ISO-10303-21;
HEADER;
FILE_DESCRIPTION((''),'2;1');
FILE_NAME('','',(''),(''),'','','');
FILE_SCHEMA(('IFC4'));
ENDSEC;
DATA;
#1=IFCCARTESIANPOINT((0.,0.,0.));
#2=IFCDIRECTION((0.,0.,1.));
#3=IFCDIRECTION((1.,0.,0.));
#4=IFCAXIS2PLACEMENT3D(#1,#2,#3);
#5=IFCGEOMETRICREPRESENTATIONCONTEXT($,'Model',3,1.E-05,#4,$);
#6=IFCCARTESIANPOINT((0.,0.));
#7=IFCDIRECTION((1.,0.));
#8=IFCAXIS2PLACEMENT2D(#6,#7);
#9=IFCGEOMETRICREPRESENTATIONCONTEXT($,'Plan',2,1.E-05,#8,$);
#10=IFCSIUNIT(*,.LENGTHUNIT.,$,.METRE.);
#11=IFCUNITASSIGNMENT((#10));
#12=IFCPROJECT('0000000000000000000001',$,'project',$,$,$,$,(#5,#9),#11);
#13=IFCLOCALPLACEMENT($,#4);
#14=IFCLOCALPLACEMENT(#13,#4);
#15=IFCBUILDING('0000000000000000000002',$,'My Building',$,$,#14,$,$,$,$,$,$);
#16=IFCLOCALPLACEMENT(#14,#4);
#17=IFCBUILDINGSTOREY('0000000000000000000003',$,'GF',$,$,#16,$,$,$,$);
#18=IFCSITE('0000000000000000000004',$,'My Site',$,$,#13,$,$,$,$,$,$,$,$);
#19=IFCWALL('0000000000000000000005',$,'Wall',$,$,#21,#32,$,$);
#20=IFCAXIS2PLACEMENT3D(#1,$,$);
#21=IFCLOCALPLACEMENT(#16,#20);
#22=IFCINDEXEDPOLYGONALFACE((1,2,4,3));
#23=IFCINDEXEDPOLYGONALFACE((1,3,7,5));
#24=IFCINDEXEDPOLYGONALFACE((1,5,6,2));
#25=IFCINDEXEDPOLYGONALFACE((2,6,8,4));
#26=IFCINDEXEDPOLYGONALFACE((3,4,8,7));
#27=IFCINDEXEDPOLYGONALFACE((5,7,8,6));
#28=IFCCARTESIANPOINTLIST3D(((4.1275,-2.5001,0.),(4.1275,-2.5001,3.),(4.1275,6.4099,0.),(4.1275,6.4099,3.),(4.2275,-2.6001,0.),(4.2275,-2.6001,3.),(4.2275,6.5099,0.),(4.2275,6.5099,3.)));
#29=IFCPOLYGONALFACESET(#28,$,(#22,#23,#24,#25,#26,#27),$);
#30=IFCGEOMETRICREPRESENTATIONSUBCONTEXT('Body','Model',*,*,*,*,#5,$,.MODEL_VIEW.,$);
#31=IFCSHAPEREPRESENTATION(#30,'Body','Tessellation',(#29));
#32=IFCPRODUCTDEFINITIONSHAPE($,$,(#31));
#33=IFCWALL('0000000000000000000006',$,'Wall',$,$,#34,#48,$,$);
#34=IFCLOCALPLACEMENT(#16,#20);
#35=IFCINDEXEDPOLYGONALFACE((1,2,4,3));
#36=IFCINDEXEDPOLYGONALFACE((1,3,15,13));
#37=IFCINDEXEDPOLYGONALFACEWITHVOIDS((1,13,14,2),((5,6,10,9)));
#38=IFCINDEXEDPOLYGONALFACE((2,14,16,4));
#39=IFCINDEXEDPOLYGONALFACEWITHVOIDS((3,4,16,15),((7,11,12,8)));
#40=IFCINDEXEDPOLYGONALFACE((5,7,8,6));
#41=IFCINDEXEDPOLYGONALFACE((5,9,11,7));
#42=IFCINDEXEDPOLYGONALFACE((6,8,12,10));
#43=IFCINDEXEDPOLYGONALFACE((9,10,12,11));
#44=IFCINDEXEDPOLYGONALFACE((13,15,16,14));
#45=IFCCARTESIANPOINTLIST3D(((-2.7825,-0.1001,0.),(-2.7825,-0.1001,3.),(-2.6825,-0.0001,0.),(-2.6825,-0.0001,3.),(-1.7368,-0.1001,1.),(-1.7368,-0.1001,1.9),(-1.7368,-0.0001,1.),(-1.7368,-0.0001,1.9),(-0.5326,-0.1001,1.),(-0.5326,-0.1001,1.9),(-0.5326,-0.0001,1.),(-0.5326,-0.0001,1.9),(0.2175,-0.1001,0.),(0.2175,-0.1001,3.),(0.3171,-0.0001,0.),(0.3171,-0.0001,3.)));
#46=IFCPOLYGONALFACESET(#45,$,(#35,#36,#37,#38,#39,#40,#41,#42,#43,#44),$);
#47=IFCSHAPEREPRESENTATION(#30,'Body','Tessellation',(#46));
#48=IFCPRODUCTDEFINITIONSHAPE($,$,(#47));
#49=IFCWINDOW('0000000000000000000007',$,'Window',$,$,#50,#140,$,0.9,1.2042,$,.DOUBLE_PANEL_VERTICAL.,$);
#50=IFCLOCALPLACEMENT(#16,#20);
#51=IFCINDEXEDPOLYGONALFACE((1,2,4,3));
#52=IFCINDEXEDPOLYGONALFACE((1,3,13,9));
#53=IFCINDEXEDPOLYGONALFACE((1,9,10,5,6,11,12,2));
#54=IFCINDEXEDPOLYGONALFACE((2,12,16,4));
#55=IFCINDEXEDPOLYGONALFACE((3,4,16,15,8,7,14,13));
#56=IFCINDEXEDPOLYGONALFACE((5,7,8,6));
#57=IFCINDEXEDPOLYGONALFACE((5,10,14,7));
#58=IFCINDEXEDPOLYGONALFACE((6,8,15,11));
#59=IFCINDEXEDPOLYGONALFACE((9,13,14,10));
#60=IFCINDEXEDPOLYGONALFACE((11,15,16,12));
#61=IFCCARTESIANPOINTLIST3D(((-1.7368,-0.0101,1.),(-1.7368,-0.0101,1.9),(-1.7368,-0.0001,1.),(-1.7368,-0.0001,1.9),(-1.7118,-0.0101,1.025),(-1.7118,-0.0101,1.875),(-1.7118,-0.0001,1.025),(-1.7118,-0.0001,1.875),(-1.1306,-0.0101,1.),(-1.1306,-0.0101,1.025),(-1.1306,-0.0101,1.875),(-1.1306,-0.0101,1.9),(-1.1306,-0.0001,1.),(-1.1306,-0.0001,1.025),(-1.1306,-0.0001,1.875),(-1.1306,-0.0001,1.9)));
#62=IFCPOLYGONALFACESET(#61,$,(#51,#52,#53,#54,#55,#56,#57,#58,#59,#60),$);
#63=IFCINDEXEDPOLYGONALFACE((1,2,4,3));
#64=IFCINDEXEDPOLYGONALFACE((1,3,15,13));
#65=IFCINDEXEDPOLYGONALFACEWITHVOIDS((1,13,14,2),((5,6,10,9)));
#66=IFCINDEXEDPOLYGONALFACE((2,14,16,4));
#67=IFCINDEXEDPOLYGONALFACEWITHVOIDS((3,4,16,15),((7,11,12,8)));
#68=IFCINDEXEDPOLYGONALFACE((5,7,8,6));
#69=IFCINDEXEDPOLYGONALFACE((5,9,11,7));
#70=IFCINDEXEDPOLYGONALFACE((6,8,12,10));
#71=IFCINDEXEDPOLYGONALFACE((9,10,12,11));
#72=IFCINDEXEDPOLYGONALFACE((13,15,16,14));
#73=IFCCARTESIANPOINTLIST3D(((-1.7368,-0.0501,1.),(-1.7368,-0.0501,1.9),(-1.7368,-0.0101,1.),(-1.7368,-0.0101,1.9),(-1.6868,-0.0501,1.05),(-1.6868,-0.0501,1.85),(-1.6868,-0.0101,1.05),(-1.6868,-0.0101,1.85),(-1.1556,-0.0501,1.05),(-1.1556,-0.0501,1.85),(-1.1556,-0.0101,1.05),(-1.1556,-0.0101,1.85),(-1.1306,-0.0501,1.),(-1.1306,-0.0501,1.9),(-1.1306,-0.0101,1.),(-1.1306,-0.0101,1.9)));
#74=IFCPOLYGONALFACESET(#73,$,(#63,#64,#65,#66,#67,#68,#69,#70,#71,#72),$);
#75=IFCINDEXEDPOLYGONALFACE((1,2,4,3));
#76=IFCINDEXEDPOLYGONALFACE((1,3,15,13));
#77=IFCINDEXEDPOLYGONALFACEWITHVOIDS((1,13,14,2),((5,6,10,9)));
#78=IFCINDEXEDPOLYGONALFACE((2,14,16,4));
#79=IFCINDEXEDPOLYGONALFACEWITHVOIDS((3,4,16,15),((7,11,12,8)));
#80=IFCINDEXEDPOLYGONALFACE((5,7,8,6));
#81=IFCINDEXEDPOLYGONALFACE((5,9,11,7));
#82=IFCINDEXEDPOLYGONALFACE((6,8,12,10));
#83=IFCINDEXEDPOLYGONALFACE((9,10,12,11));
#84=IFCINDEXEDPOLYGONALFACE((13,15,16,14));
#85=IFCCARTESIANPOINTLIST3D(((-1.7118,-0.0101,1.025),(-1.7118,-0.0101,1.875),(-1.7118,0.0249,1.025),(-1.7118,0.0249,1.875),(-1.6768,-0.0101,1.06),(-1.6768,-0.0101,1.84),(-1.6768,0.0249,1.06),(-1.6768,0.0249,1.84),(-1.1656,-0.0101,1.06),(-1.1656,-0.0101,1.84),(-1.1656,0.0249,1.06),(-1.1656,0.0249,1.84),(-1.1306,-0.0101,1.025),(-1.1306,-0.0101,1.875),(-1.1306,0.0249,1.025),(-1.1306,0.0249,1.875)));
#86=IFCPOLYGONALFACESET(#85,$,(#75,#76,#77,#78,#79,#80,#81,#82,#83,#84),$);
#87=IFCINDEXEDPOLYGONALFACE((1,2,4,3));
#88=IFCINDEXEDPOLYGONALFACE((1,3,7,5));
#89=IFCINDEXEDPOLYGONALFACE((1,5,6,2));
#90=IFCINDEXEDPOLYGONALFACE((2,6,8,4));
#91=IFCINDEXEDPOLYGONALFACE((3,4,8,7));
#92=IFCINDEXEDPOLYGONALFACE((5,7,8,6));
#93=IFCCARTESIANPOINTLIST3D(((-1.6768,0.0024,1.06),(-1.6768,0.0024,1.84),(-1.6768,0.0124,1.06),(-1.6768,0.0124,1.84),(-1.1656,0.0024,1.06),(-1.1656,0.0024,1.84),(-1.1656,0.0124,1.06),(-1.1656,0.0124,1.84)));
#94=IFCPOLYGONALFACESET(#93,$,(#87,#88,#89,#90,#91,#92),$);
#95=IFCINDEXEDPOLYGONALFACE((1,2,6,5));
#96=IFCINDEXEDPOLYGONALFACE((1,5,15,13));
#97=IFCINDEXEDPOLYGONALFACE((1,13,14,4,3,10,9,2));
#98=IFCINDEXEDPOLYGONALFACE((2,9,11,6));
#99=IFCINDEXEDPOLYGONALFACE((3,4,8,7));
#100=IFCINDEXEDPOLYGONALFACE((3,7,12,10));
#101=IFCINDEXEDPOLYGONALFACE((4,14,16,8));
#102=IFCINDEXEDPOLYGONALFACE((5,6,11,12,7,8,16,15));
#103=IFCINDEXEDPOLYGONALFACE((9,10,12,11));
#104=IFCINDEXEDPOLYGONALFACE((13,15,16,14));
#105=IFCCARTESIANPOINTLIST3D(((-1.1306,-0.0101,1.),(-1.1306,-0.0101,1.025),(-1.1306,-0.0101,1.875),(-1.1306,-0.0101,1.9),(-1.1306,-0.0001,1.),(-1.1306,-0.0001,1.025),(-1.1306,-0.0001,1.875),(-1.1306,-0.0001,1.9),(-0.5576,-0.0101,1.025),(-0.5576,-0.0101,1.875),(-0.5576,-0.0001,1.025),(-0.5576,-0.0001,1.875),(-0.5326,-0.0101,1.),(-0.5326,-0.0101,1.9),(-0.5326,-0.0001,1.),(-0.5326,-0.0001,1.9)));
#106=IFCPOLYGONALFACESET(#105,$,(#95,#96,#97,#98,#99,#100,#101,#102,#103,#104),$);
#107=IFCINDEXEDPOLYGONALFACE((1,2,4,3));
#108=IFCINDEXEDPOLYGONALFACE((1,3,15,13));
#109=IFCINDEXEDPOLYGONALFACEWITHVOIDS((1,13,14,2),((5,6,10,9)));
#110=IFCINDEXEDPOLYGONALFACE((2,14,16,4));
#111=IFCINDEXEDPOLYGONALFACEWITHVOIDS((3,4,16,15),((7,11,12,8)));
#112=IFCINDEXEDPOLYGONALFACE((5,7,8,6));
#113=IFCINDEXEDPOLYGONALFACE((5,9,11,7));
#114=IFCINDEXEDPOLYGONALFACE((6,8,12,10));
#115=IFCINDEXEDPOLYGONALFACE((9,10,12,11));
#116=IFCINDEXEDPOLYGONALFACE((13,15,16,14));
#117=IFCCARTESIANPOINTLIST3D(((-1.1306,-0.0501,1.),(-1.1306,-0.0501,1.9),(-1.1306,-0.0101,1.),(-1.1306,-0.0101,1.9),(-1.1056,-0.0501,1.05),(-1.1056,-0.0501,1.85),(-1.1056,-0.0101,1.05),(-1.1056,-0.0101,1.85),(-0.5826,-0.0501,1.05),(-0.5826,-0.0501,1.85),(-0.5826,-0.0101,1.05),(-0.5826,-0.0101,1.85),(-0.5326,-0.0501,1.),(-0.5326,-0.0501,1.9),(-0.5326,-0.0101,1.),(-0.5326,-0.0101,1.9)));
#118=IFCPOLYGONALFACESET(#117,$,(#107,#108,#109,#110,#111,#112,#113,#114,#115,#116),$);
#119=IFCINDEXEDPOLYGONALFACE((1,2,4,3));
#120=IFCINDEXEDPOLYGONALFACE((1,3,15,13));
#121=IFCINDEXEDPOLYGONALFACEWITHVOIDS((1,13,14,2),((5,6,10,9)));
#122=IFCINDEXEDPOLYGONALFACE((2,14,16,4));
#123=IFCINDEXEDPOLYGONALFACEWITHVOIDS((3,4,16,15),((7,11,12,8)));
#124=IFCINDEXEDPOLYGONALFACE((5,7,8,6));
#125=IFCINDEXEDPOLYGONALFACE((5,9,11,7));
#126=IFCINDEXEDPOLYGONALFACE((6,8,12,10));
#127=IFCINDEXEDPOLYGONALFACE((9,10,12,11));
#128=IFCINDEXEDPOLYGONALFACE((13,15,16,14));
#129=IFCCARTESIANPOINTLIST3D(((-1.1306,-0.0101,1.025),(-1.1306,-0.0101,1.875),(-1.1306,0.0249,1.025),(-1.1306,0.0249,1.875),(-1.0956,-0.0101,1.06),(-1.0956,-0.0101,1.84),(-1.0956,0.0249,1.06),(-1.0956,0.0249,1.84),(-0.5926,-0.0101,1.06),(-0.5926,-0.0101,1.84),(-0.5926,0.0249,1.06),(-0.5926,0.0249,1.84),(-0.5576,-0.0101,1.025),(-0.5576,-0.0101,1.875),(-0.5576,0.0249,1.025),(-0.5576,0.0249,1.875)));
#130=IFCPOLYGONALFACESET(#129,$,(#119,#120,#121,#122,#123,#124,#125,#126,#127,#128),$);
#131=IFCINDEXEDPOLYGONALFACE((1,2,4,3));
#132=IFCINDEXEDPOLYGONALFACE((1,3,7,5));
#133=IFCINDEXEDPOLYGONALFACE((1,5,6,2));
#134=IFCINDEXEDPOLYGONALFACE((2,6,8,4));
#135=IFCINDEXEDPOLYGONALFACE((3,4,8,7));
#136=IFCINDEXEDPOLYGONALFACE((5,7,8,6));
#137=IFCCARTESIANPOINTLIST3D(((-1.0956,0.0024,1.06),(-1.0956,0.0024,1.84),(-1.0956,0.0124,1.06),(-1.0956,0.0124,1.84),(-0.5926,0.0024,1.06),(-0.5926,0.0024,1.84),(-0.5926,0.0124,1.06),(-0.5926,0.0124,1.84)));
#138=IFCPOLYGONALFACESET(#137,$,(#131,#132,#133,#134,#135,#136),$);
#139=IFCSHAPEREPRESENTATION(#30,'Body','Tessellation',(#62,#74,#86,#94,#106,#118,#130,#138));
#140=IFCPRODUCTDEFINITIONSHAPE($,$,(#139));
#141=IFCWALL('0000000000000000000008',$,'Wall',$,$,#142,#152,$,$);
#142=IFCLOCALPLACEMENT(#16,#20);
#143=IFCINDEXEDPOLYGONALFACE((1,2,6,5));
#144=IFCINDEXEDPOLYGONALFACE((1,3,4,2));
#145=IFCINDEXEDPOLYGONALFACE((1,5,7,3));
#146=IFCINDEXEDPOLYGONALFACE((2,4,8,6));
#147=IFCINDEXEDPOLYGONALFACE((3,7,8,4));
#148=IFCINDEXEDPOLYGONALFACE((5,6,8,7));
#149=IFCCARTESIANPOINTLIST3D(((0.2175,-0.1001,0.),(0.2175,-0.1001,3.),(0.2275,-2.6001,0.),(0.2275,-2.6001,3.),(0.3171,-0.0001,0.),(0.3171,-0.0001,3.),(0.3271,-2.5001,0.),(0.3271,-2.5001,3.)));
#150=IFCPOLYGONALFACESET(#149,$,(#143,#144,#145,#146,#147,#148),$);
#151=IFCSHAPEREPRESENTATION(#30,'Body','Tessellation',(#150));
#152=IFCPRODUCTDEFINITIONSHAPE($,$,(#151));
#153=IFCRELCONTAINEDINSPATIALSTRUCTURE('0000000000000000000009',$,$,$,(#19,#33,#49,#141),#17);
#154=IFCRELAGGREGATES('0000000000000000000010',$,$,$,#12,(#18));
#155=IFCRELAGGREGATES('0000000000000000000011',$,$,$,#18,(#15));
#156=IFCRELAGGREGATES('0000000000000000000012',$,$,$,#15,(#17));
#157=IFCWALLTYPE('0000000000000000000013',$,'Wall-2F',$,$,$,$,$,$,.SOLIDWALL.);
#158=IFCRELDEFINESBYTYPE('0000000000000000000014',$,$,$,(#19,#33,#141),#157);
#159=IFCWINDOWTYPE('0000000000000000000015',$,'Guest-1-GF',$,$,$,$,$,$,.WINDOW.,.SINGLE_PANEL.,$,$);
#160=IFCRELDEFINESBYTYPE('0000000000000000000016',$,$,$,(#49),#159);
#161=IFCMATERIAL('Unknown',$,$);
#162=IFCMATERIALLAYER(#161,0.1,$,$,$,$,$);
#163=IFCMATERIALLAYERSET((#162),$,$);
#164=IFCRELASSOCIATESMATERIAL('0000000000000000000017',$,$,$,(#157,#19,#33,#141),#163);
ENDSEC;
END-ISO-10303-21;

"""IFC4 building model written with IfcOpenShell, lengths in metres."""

from ifc_helpers import new_model, entity, si_unit, frame, origin_with_axes, origin_2d_with_axis, place, context, subcontext, project, spatial, line, indexed_curve, outline, extrude, shape, source, transform, mapped, material, layer, layer_set, layer_usage, type_object, type_shapes, element, fill, save


model = new_model("IFC4")

# Units and contexts
model_context = context("Model", 3, precision=1e-05, world=origin_with_axes())
plan_context = context("Plan", 2, precision=1e-05, world=origin_2d_with_axis())
body_context_1 = subcontext(model_context, "Body", "Model", "MODEL_VIEW")
body_context_2 = subcontext(plan_context, "Body", "Plan", "PLAN_VIEW")
ifc_project = project(units=[si_unit("LENGTHUNIT", "METRE")], contexts=[model_context, plan_context])

# Site, building, storey
site_placement = place(None, origin_with_axes())
site = spatial("IfcSite", under=ifc_project, at=site_placement, Name="My Site")
building_placement = place(site_placement, origin_with_axes())
building = spatial("IfcBuilding", under=site, at=building_placement, Name="My Building")
storey_placement = place(building_placement, origin_with_axes())
storey = spatial("IfcBuildingStorey", under=building, at=storey_placement, Name="GF")

# Shared definitions
ifc_material = material(Name="Unknown")

# Shared definitions
ifc_layer_1 = layer(ifc_material, 0.1)
ifc_layer_set_1 = layer_set([ifc_layer_1])
wall_type = type_object("IfcWallType", Name="Wall-2F", PredefinedType="SOLIDWALL", material=ifc_layer_set_1)

# Wall
ifc_layer_usage_1 = layer_usage(ifc_layer_set_1, "AXIS2", "POSITIVE", 0.0)
wall_1_placement = place(storey_placement, frame((4.2275, -2.6001, 0.0), z_axis=(0.0, 0.0, 1.0), x_axis=(0.0, 1.0, 0.0)))
element("IfcWall", 1, at=wall_1_placement, inside=storey, type_object=wall_type, material=ifc_layer_usage_1, Name="Wall", context=body_context_1, shape_type="SweptSolid", body=[
    extrude(outline(indexed_curve([(0.0, 0.0), (0.1, 0.1), (9.01, 0.1), (9.11, 0.0)], segments=[line(1, 2, 3, 4, 1)])), origin_with_axes(), (0.0, 0.0, 1.0), 3.0),
])

# Wall, opening, window
ifc_layer_usage_2 = layer_usage(ifc_layer_set_1, "AXIS2", "POSITIVE", 0.0)
wall_2_placement = place(storey_placement, frame((-2.7825, -0.1001, 0.0), z_axis=(0.0, 0.0, 1.0), x_axis=(1.0, 0.0, 0.0)))
wall_2 = element("IfcWall", 2, at=wall_2_placement, inside=storey, type_object=wall_type, material=ifc_layer_usage_2, Name="Wall", context=body_context_1, shape_type="SweptSolid", body=[
    extrude(outline(indexed_curve([(0.0, 0.0), (0.1, 0.1), (3.0996, 0.1), (3.0, 0.0)], segments=[line(1, 2, 3, 4, 1)])), origin_with_axes(), (0.0, 0.0, 1.0), 3.0),
])
shared_shape_1 = source(origin_with_axes(), body_context_1, "Body", "SweptSolid", [
    extrude(outline(indexed_curve([(0.0, 0.0), (1.2042, 0.0), (1.2042, 0.9), (0.0, 0.9)], segments=[line(1, 2, 3, 4, 1)])), frame((0.0, -0.6, 0.0), z_axis=(0.0, -1.0, 0.0), x_axis=(1.0, 0.0, 0.0)), (0.0, 0.0, -1.0), 1.2),
])
opening_1_placement = place(wall_2_placement, frame((1.0457, 0.0, 1.0), z_axis=(0.0, 0.0, 1.0), x_axis=(1.0, 0.0, 0.0)))
opening_1 = element("IfcOpeningElement", 3, at=opening_1_placement, cuts=wall_2, PredefinedType="OPENING", context=body_context_1, shape_type="MappedRepresentation", body=[
    mapped(shared_shape_1, transform((0.0, 0.0, 0.0), x_axis=(1.0, 0.0, 0.0), y_axis=(0.0, 1.0, 0.0), z_axis=(0.0, 0.0, 1.0), scale=1.0)),
])
window_type_1 = type_object("IfcWindowType", Name="Guest-1-GF", PartitioningType="SINGLE_PANEL", PredefinedType="WINDOW")
shared_shape_2 = source(origin_with_axes(), body_context_1, "Body", "SweptSolid", [
    extrude(outline(indexed_curve([(0.6062, 0.0), (0.0, 0.0), (0.0, 0.9), (0.6062, 0.9), (0.6062, 0.875), (0.025, 0.875), (0.025, 0.025), (0.6062, 0.025)], segments=[line(1, 2, 3, 4, 5, 6, 7, 8, 1)])), frame((0.0, 0.09, 0.0), z_axis=(0.0, -1.0, 0.0), x_axis=(1.0, 0.0, 0.0)), (0.0, 0.0, -1.0), 0.01),
    extrude(outline(indexed_curve([(0.0, 0.0), (0.6062, 0.0), (0.6062, 0.9), (0.0, 0.9)], segments=[line(1, 2, 3, 4, 1)]), holes=[indexed_curve([(0.05, 0.05), (0.5812, 0.05), (0.5812, 0.85), (0.05, 0.85)], segments=[line(1, 2, 3, 4, 1)])]), frame((0.0, 0.05, 0.0), z_axis=(0.0, -1.0, 0.0), x_axis=(1.0, 0.0, 0.0)), (0.0, 0.0, -1.0), 0.04),
    extrude(outline(indexed_curve([(0.0, 0.0), (0.5812, 0.0), (0.5812, 0.85), (0.0, 0.85)], segments=[line(1, 2, 3, 4, 1)]), holes=[indexed_curve([(0.035, 0.035), (0.5462, 0.035), (0.5462, 0.815), (0.035, 0.815)], segments=[line(1, 2, 3, 4, 1)])]), frame((0.025, 0.09, 0.025), z_axis=(0.0, -1.0, 0.0), x_axis=(1.0, 0.0, 0.0)), (0.0, 0.0, -1.0), 0.035),
    extrude(outline(indexed_curve([(0.035, 0.035), (0.5462, 0.035), (0.5462, 0.815), (0.035, 0.815)], segments=[line(1, 2, 3, 4, 1)])), frame((0.025, 0.1025, 0.025), z_axis=(0.0, -1.0, 0.0), x_axis=(1.0, 0.0, 0.0)), (0.0, 0.0, -1.0), 0.01),
    extrude(outline(indexed_curve([(0.0, 0.9), (0.598, 0.9), (0.598, 0.0), (0.0, 0.0), (0.0, 0.025), (0.573, 0.025), (0.573, 0.875), (0.0, 0.875)], segments=[line(1, 2, 3, 4, 5, 6, 7, 8, 1)])), frame((0.6062, 0.09, 0.0), z_axis=(0.0, -1.0, 0.0), x_axis=(1.0, 0.0, 0.0)), (0.0, 0.0, -1.0), 0.01),
    extrude(outline(indexed_curve([(0.0, 0.0), (0.598, 0.0), (0.598, 0.9), (0.0, 0.9)], segments=[line(1, 2, 3, 4, 1)]), holes=[indexed_curve([(0.025, 0.05), (0.548, 0.05), (0.548, 0.85), (0.025, 0.85)], segments=[line(1, 2, 3, 4, 1)])]), frame((0.6062, 0.05, 0.0), z_axis=(0.0, -1.0, 0.0), x_axis=(1.0, 0.0, 0.0)), (0.0, 0.0, -1.0), 0.04),
    extrude(outline(indexed_curve([(0.0, 0.0), (0.573, 0.0), (0.573, 0.85), (0.0, 0.85)], segments=[line(1, 2, 3, 4, 1)]), holes=[indexed_curve([(0.035, 0.035), (0.538, 0.035), (0.538, 0.815), (0.035, 0.815)], segments=[line(1, 2, 3, 4, 1)])]), frame((0.6062, 0.09, 0.025), z_axis=(0.0, -1.0, 0.0), x_axis=(1.0, 0.0, 0.0)), (0.0, 0.0, -1.0), 0.035),
    extrude(outline(indexed_curve([(0.035, 0.035), (0.538, 0.035), (0.538, 0.815), (0.035, 0.815)], segments=[line(1, 2, 3, 4, 1)])), frame((0.6062, 0.1025, 0.025), z_axis=(0.0, -1.0, 0.0), x_axis=(1.0, 0.0, 0.0)), (0.0, 0.0, -1.0), 0.01),
])
shared_shape_3 = source(origin_with_axes(), body_context_2, "Body", "Curve2D", [
    entity("IfcIndexedPolyCurve", entity("IfcCartesianPointList2D", [[0.05, 0.05], [0.5812, 0.05]])),
    entity("IfcIndexedPolyCurve", entity("IfcCartesianPointList2D", [[0.0, 0.1], [0.025, 0.1], [0.025, 0.09], [0.05, 0.09], [0.05, 0.05], [0.0, 0.05]]), [entity("IfcLineIndex", [1, 2, 3, 4, 5, 6, 1])]),
    entity("IfcIndexedPolyCurve", entity("IfcCartesianPointList2D", [[0.6062, 0.1], [0.6062, 0.1], [0.6062, 0.09], [0.5812, 0.09], [0.5812, 0.05], [0.6062, 0.05]])),
    entity("IfcIndexedPolyCurve", entity("IfcCartesianPointList2D", [[0.025, 0.09], [0.06, 0.09], [0.06, 0.125], [0.025, 0.125]]), [entity("IfcLineIndex", [1, 2, 3, 4, 1])]),
    entity("IfcIndexedPolyCurve", entity("IfcCartesianPointList2D", [[0.6062, 0.09], [0.5712, 0.09], [0.5712, 0.125], [0.6062, 0.125]]), [entity("IfcLineIndex", [1, 2, 3, 4, 1])]),
    entity("IfcIndexedPolyCurve", entity("IfcCartesianPointList2D", [[0.06, 0.09], [0.5712, 0.09]])),
    entity("IfcIndexedPolyCurve", entity("IfcCartesianPointList2D", [[0.06, 0.125], [0.5712, 0.125]])),
    entity("IfcIndexedPolyCurve", entity("IfcCartesianPointList2D", [[0.06, 0.1075], [0.5712, 0.1075]])),
    entity("IfcIndexedPolyCurve", entity("IfcCartesianPointList2D", [[0.6312, 0.05], [1.1542, 0.05]])),
    entity("IfcIndexedPolyCurve", entity("IfcCartesianPointList2D", [[0.6062, 0.1], [0.6062, 0.1], [0.6062, 0.09], [0.6312, 0.09], [0.6312, 0.05], [0.6062, 0.05]])),
    entity("IfcIndexedPolyCurve", entity("IfcCartesianPointList2D", [[1.2042, 0.1], [1.1792, 0.1], [1.1792, 0.09], [1.1542, 0.09], [1.1542, 0.05], [1.2042, 0.05]]), [entity("IfcLineIndex", [1, 2, 3, 4, 5, 6, 1])]),
    entity("IfcIndexedPolyCurve", entity("IfcCartesianPointList2D", [[0.6062, 0.09], [0.6412, 0.09], [0.6412, 0.125], [0.6062, 0.125]]), [entity("IfcLineIndex", [1, 2, 3, 4, 1])]),
    entity("IfcIndexedPolyCurve", entity("IfcCartesianPointList2D", [[1.1792, 0.09], [1.1442, 0.09], [1.1442, 0.125], [1.1792, 0.125]]), [entity("IfcLineIndex", [1, 2, 3, 4, 1])]),
    entity("IfcIndexedPolyCurve", entity("IfcCartesianPointList2D", [[0.6412, 0.09], [1.1442, 0.09]])),
    entity("IfcIndexedPolyCurve", entity("IfcCartesianPointList2D", [[0.6412, 0.125], [1.1442, 0.125]])),
    entity("IfcIndexedPolyCurve", entity("IfcCartesianPointList2D", [[0.6412, 0.1075], [1.1442, 0.1075]])),
])
type_shapes(window_type_1, [shared_shape_2, shared_shape_3])
window_1_placement = place(opening_1_placement, frame((0.0, 0.0, 0.0), z_axis=(0.0, 0.0, 1.0), x_axis=(1.0, 0.0, 0.0)))
window_1 = element("IfcWindow", 4, at=window_1_placement, inside=storey, type_object=window_type_1, Name="Window", OverallHeight=0.9, OverallWidth=1.2042, PartitioningType="DOUBLE_PANEL_VERTICAL", shapes=[
    shape(body_context_1, "Body", "MappedRepresentation", [mapped(shared_shape_2, transform((0.0, 0.0, 0.0), x_axis=(1.0, 0.0, 0.0), y_axis=(0.0, 1.0, 0.0), z_axis=(0.0, 0.0, 1.0), scale=1.0))]),
    shape(body_context_2, "Body", "MappedRepresentation", [mapped(shared_shape_3, transform((0.0, 0.0, 0.0), x_axis=(1.0, 0.0, 0.0), y_axis=(0.0, 1.0, 0.0), z_axis=(0.0, 0.0, 1.0), scale=1.0))]),
])
fill(opening_1, window_1)

# Wall
ifc_layer_usage_3 = layer_usage(ifc_layer_set_1, "AXIS2", "POSITIVE", 0.0)
wall_3_placement = place(storey_placement, frame((0.2175, -0.1001, 0.0), z_axis=(0.0, 0.0, 1.0), x_axis=(0.004, -0.999992, 0.0)))
element("IfcWall", 5, at=wall_3_placement, inside=storey, type_object=wall_type, material=ifc_layer_usage_3, Name="Wall", context=body_context_1, shape_type="SweptSolid", body=[
    extrude(outline(indexed_curve([(0.0, 0.0), (-0.0996, 0.1), (2.4004, 0.1), (2.5, 0.0)], segments=[line(1, 2, 3, 4, 1)])), origin_with_axes(), (0.0, 0.0, 1.0), 3.0),
])

save(model, "model.ifc")
